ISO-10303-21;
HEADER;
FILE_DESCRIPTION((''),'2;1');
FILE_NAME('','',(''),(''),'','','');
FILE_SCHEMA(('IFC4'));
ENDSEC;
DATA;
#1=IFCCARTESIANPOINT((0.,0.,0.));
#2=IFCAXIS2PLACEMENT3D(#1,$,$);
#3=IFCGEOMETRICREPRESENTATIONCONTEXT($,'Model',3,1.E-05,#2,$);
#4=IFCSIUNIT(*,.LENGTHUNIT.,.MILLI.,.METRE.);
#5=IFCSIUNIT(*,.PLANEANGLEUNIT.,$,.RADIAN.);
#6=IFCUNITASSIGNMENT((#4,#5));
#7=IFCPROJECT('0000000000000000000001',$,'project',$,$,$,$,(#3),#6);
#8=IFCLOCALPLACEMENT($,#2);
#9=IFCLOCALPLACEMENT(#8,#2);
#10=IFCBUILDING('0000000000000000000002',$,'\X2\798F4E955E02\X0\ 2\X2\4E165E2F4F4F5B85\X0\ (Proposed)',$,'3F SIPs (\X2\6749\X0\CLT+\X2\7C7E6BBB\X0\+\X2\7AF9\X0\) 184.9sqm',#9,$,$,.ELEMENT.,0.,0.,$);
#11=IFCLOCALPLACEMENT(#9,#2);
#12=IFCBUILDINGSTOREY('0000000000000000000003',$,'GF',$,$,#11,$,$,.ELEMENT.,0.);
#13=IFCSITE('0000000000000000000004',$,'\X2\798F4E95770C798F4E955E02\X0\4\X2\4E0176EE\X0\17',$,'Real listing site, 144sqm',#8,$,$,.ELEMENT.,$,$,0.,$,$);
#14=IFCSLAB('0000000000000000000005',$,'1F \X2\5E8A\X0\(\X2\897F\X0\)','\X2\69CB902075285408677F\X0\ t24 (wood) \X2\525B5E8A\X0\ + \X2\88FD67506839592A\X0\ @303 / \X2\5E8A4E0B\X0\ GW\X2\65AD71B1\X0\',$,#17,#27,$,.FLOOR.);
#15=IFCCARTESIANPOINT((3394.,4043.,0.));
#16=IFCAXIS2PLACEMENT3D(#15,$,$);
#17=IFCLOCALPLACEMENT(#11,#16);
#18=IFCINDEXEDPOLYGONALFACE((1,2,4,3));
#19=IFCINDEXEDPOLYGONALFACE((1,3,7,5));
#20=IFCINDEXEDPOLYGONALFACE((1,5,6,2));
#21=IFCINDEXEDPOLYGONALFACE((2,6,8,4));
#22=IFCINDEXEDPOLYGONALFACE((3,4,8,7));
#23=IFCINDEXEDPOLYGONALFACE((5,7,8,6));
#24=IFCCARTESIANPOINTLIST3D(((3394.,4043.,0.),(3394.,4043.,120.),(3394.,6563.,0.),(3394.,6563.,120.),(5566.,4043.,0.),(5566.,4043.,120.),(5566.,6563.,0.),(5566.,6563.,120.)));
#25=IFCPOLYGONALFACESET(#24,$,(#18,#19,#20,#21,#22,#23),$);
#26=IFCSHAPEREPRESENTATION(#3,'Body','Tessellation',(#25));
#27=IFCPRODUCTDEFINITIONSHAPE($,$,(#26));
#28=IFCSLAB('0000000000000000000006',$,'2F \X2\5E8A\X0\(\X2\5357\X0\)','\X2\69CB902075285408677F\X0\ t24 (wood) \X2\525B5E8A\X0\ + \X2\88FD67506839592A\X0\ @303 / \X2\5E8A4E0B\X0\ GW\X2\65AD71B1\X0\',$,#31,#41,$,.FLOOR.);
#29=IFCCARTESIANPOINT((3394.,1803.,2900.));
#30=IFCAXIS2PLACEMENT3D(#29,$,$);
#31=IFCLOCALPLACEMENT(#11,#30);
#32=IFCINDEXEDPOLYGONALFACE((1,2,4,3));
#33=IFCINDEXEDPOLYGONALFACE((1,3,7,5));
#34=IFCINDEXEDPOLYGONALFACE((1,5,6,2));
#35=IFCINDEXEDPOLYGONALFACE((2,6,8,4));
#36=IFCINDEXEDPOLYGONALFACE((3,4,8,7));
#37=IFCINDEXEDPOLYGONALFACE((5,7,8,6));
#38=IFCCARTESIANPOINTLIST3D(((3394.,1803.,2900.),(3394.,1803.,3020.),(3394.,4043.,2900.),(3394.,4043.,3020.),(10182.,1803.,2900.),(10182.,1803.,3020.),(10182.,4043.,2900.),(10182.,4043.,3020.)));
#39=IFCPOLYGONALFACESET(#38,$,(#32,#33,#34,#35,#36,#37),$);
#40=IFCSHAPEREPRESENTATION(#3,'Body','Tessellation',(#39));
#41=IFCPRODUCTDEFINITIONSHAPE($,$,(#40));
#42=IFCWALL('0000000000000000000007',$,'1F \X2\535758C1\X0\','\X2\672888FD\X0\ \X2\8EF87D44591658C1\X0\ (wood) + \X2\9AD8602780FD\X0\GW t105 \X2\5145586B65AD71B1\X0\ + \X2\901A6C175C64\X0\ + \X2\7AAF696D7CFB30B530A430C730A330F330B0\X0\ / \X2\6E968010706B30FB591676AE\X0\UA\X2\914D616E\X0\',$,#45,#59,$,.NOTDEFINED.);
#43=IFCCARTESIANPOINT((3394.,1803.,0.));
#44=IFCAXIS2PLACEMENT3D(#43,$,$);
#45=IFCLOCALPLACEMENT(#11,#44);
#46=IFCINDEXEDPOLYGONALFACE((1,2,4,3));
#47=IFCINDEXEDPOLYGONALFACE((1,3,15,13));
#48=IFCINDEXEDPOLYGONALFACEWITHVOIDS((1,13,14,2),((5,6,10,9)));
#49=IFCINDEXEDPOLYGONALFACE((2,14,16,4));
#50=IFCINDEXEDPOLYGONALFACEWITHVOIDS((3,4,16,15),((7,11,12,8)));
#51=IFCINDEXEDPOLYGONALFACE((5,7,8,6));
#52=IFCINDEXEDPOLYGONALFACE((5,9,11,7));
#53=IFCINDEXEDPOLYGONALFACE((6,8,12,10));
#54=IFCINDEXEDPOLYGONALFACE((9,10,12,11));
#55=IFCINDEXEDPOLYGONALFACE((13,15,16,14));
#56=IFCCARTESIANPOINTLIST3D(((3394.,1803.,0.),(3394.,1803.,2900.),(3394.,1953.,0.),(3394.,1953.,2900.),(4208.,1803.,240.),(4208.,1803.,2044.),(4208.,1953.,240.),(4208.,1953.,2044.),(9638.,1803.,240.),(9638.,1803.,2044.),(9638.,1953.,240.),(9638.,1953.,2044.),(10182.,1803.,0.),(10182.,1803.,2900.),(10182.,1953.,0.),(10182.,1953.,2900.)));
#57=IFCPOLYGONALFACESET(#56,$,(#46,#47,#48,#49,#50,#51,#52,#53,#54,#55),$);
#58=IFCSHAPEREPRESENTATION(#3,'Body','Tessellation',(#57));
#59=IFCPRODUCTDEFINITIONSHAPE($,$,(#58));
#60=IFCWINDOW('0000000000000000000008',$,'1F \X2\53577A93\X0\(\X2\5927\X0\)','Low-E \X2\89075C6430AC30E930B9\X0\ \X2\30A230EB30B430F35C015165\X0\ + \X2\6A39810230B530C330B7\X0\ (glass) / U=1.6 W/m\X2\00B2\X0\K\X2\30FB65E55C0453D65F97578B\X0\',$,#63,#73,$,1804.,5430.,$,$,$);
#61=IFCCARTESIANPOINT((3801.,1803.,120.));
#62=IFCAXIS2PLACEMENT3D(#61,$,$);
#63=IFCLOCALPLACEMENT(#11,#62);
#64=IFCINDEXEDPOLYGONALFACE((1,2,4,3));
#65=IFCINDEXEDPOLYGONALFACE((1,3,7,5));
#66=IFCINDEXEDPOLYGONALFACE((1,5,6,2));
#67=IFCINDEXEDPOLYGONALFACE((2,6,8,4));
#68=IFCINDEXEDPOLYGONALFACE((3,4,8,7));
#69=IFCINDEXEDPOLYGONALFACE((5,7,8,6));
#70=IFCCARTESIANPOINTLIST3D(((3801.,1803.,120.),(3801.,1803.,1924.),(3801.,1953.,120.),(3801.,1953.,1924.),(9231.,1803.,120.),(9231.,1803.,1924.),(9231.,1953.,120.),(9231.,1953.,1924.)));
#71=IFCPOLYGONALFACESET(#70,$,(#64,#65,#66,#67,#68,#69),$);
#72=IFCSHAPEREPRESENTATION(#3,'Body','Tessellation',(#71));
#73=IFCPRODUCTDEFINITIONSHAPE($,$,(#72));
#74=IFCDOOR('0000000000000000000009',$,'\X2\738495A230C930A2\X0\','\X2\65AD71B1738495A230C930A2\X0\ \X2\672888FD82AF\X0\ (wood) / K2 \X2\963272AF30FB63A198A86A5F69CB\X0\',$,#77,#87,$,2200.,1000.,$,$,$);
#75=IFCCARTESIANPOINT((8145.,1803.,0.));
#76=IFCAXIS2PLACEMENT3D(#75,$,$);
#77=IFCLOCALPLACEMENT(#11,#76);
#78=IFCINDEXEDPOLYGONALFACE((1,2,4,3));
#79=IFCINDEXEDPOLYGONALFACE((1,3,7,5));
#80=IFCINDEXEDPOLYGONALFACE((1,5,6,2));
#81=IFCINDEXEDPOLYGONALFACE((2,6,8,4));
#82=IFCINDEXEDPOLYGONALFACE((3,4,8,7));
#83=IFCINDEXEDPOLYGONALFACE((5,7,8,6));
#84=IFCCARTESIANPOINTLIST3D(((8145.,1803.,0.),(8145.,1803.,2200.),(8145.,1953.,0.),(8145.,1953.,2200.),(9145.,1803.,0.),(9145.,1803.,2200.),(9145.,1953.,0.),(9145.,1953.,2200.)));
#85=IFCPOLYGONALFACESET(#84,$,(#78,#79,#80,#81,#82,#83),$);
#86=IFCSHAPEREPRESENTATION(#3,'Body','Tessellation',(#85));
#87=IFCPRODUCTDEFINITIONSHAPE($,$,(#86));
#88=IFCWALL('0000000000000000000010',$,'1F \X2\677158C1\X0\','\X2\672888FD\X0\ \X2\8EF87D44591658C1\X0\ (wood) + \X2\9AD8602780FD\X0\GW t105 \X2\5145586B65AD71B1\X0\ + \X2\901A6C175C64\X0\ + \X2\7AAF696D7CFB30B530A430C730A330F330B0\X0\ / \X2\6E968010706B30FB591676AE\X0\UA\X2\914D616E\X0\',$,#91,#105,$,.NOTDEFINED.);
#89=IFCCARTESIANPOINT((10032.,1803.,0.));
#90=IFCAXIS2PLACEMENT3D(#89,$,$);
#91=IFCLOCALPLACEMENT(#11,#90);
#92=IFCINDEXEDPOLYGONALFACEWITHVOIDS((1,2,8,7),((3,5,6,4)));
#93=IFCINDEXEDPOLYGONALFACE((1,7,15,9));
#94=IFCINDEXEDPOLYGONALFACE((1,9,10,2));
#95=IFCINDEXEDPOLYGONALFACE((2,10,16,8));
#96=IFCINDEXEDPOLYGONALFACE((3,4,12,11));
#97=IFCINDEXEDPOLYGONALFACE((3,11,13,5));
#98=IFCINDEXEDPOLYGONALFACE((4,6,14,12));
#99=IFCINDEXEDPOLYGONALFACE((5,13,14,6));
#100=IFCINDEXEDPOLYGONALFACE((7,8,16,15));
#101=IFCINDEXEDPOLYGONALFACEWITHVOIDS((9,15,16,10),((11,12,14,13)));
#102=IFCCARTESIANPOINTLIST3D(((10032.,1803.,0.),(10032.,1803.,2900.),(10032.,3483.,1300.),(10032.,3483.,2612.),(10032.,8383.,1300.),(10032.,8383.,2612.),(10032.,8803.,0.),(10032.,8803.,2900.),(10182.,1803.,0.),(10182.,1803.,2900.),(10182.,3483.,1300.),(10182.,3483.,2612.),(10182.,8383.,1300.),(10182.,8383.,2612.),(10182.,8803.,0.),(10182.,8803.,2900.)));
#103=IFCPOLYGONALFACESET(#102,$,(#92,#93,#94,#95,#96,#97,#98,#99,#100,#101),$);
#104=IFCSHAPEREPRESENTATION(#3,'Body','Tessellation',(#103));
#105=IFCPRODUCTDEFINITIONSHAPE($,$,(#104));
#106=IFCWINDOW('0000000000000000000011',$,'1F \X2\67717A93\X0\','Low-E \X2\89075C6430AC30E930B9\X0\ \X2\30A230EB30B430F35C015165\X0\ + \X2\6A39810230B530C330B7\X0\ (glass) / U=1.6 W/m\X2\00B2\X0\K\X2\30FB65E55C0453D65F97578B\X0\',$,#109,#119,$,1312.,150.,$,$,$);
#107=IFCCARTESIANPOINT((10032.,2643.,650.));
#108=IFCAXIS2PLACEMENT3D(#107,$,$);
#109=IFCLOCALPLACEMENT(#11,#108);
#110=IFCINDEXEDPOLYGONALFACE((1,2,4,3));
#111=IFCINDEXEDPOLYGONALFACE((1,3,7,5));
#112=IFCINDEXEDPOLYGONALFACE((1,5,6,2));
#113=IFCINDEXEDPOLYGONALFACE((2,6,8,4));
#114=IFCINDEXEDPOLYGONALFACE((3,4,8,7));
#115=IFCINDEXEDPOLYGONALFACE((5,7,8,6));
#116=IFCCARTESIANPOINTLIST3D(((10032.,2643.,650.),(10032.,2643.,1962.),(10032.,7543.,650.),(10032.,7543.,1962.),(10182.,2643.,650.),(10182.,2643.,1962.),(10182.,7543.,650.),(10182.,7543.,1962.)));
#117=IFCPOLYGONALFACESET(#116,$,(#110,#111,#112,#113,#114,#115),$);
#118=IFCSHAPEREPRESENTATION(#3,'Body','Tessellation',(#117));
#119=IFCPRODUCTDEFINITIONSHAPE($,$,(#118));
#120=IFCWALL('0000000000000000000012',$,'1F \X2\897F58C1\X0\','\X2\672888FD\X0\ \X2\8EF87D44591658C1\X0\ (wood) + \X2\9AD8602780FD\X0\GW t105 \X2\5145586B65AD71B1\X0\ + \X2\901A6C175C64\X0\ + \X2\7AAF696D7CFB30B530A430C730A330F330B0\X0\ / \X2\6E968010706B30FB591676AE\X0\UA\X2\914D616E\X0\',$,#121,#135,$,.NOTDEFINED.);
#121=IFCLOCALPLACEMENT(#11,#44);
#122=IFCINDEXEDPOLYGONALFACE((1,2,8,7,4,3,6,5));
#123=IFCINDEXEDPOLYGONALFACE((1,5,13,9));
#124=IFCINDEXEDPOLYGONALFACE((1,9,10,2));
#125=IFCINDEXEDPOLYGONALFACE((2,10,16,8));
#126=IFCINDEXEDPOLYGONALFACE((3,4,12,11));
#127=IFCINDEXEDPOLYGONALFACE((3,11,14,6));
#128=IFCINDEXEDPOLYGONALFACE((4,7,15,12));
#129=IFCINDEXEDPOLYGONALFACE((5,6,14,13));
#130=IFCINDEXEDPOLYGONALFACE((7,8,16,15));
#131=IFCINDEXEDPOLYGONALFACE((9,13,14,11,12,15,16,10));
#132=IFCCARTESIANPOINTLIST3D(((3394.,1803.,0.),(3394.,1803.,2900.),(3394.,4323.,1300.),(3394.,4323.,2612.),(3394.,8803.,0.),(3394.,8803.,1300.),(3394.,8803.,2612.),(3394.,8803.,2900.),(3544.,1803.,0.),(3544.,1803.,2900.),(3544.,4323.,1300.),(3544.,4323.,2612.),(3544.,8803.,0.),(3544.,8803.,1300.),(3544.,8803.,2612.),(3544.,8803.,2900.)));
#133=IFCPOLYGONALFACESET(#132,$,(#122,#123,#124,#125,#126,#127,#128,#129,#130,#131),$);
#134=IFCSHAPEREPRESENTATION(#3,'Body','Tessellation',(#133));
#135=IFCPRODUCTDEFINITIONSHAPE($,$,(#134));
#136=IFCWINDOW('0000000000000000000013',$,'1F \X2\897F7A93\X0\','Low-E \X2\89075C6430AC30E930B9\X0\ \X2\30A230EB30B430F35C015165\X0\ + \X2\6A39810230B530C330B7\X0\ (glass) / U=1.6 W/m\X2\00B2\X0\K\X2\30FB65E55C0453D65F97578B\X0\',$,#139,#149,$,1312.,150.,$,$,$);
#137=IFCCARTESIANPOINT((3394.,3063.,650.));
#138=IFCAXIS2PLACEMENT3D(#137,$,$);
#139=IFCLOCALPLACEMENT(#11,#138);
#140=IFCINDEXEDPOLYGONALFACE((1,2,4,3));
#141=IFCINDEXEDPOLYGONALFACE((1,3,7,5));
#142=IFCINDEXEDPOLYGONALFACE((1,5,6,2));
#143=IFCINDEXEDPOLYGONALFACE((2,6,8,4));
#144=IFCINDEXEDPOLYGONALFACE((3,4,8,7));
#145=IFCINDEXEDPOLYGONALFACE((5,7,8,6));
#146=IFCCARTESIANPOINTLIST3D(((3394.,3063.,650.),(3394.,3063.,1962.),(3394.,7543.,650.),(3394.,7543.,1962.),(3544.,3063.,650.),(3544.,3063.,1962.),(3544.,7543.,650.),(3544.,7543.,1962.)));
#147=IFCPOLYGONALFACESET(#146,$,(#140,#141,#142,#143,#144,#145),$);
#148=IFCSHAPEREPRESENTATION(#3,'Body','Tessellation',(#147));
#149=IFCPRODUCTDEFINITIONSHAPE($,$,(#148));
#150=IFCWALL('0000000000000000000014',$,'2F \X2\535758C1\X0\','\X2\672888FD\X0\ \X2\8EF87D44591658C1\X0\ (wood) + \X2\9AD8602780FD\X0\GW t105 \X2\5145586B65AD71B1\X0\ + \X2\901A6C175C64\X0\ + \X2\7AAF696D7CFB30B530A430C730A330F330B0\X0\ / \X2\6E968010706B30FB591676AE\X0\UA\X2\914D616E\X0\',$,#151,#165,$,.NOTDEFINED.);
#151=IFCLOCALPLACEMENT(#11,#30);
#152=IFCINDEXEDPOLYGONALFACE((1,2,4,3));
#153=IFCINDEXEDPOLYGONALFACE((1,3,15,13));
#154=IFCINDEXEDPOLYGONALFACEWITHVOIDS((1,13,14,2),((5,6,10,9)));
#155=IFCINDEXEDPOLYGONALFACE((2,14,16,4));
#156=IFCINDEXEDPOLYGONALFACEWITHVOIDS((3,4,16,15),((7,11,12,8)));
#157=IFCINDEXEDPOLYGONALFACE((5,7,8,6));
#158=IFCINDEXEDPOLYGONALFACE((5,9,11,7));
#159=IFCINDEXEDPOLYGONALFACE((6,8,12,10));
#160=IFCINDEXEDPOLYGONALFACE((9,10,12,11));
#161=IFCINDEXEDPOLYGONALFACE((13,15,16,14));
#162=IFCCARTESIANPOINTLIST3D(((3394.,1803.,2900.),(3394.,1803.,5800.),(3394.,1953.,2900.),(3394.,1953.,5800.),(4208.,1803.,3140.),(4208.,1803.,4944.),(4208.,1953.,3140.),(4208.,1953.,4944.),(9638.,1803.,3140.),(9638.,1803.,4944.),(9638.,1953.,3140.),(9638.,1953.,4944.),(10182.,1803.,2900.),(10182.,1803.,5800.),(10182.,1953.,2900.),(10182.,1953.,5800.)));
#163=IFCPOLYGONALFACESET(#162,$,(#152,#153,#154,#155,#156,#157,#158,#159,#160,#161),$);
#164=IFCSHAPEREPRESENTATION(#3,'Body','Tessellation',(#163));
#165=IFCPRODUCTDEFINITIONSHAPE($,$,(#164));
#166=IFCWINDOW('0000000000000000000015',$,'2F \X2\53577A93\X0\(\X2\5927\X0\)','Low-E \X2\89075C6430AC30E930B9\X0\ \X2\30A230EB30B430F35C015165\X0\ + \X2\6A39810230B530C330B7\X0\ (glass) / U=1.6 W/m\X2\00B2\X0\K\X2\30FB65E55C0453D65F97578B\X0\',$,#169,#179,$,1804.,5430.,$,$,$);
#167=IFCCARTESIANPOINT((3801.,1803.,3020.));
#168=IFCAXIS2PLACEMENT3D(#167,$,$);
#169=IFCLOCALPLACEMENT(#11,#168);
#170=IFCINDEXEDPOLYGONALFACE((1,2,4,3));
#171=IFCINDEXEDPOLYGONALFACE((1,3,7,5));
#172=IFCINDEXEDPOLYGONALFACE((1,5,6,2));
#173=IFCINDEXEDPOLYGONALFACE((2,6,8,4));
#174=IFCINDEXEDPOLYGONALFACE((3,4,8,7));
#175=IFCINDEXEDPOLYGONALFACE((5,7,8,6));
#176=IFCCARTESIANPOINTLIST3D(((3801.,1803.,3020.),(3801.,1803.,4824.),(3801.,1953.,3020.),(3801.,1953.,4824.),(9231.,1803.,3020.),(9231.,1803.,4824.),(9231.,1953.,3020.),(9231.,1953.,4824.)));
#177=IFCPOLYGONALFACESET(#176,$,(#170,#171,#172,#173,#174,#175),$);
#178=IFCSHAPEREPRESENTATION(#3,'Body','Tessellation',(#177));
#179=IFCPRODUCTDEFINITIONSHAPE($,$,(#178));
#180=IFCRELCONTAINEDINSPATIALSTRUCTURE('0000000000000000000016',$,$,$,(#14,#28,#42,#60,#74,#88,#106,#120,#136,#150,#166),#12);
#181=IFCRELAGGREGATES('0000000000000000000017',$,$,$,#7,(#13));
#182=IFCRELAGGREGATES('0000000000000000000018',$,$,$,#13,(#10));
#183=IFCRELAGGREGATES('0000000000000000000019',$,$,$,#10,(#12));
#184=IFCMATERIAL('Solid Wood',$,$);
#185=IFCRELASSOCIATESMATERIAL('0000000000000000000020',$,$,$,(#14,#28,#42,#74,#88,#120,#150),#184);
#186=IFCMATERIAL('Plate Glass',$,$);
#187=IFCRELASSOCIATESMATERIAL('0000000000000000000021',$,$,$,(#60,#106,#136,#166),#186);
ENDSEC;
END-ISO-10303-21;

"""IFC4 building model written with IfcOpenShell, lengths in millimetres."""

from ifc_helpers import new_model, si_unit, frame, frame_2d, origin, place, context, project, spatial, rectangle, extrude, material, element, fill, save


model = new_model("IFC4")

# Units and contexts
model_context = context("Model", 3, precision=1e-05, world=origin())
ifc_project = project(units=[si_unit("LENGTHUNIT", "METRE", prefix="MILLI"), si_unit("PLANEANGLEUNIT", "RADIAN")], contexts=[model_context])

# Site, building, storey
site_placement = place(None, origin())
site = spatial("IfcSite", under=ifc_project, at=site_placement, Name="福井県福井市4丁目17", ObjectType="Real listing site, 144sqm", CompositionType="ELEMENT", RefElevation=0.0)
building_placement = place(site_placement, origin())
building = spatial("IfcBuilding", under=site, at=building_placement, Name="福井市 2世帯住宅 (Proposed)", ObjectType="3F SIPs (杉CLT+籾殻+竹) 184.9sqm", CompositionType="ELEMENT", ElevationOfRefHeight=0.0, ElevationOfTerrain=0.0)
storey_placement = place(building_placement, origin())
storey = spatial("IfcBuildingStorey", under=building, at=storey_placement, Name="GF", CompositionType="ELEMENT", Elevation=0.0)

# Slabs
ifc_material_1 = material(Name="Solid Wood")
slab_1_placement = place(storey_placement, frame((3394.0, 4043.0, 0.0)))
element("IfcSlab", 1, at=slab_1_placement, inside=storey, material=ifc_material_1, Name="1F 床(西)", Description="構造用合板 t24 (wood) 剛床 + 製材根太 @303 / 床下 GW断熱", PredefinedType="FLOOR", context=model_context, shape_type="SweptSolid", body=[
    extrude(rectangle(XDim=2172.0, YDim=2520.0, at=frame_2d((1086.0, 1260.0))), frame((3394.0, 4043.0, 0.0)), (0.0, 0.0, 1.0), 120.0),
])
slab_2_placement = place(storey_placement, frame((3394.0, 1803.0, 2900.0)))
element("IfcSlab", 2, at=slab_2_placement, inside=storey, material=ifc_material_1, Name="2F 床(南)", Description="構造用合板 t24 (wood) 剛床 + 製材根太 @303 / 床下 GW断熱", PredefinedType="FLOOR", context=model_context, shape_type="SweptSolid", body=[
    extrude(rectangle(XDim=6788.0, YDim=2240.0, at=frame_2d((3394.0, 1120.0))), frame((3394.0, 1803.0, 2900.0)), (0.0, 0.0, 1.0), 120.0),
])

# Wall, openings, window, door
wall_1_placement = place(storey_placement, frame((3394.0, 1803.0, 0.0)))
wall_1 = element("IfcWall", 3, at=wall_1_placement, inside=storey, material=ifc_material_1, Name="1F 南壁", Description="木製 軸組外壁 (wood) + 高性能GW t105 充填断熱 + 通気層 + 窯業系サイディング / 準耐火・外皮UA配慮", PredefinedType="NOTDEFINED", context=model_context, shape_type="SweptSolid", body=[
    extrude(rectangle(XDim=6788.0, YDim=150.0, at=frame_2d((3394.0, 75.0))), frame((3394.0, 1803.0, 0.0)), (0.0, 0.0, 1.0), 2900.0),
])
opening_1_placement = place(storey_placement, frame((3801.0, 1803.0, 120.0)))
opening_1 = element("IfcOpeningElement", 4, at=opening_1_placement, cuts=wall_1, PredefinedType="NOTDEFINED", context=model_context, shape_type="SweptSolid", body=[
    extrude(rectangle(XDim=5430.0, YDim=150.0, at=frame_2d((2715.0, 75.0))), frame((3801.0, 1803.0, 120.0)), (0.0, 0.0, 1.0), 1804.0),
])
opening_2_placement = place(storey_placement, frame((8145.0, 1803.0, 0.0)))
opening_2 = element("IfcOpeningElement", 5, at=opening_2_placement, cuts=wall_1, PredefinedType="NOTDEFINED", context=model_context, shape_type="SweptSolid", body=[
    extrude(rectangle(XDim=1000.0, YDim=150.0, at=frame_2d((500.0, 75.0))), frame((8145.0, 1803.0, 0.0)), (0.0, 0.0, 1.0), 2200.0),
])
ifc_material_2 = material(Name="Plate Glass")
window_1_placement = place(storey_placement, frame((3801.0, 1803.0, 120.0)))
window_1 = element("IfcWindow", 6, at=window_1_placement, inside=storey, material=ifc_material_2, Name="1F 南窓(大)", Description="Low-E 複層ガラス アルゴン封入 + 樹脂サッシ (glass) / U=1.6 W/m²K・日射取得型", OverallHeight=1804.0, OverallWidth=5430.0, context=model_context, shape_type="SweptSolid", body=[
    extrude(rectangle(XDim=5430.0, YDim=150.0, at=frame_2d((2715.0, 75.0))), frame((3801.0, 1803.0, 120.0)), (0.0, 0.0, 1.0), 1804.0),
])
fill(opening_1, window_1)
door_placement = place(storey_placement, frame((8145.0, 1803.0, 0.0)))
door = element("IfcDoor", 7, at=door_placement, inside=storey, material=ifc_material_1, Name="玄関ドア", Description="断熱玄関ドア 木製芯 (wood) / K2 防犯・採風機構", OverallHeight=2200.0, OverallWidth=1000.0, context=model_context, shape_type="SweptSolid", body=[
    extrude(rectangle(XDim=1000.0, YDim=150.0, at=frame_2d((500.0, 75.0))), frame((8145.0, 1803.0, 0.0)), (0.0, 0.0, 1.0), 2200.0),
])
fill(opening_2, door)

# Walls, openings, windows
wall_2_placement = place(storey_placement, frame((10032.0, 1803.0, 0.0)))
wall_2 = element("IfcWall", 8, at=wall_2_placement, inside=storey, material=ifc_material_1, Name="1F 東壁", Description="木製 軸組外壁 (wood) + 高性能GW t105 充填断熱 + 通気層 + 窯業系サイディング / 準耐火・外皮UA配慮", PredefinedType="NOTDEFINED", context=model_context, shape_type="SweptSolid", body=[
    extrude(rectangle(XDim=150.0, YDim=7000.0, at=frame_2d((75.0, 3500.0))), frame((10032.0, 1803.0, 0.0)), (0.0, 0.0, 1.0), 2900.0),
])
opening_3_placement = place(storey_placement, frame((10032.0, 2643.0, 650.0)))
opening_3 = element("IfcOpeningElement", 9, at=opening_3_placement, cuts=wall_2, PredefinedType="NOTDEFINED", context=model_context, shape_type="SweptSolid", body=[
    extrude(rectangle(XDim=150.0, YDim=4900.0, at=frame_2d((75.0, 2450.0))), frame((10032.0, 2643.0, 650.0)), (0.0, 0.0, 1.0), 1312.0),
])
window_2_placement = place(storey_placement, frame((10032.0, 2643.0, 650.0)))
window_2 = element("IfcWindow", 10, at=window_2_placement, inside=storey, material=ifc_material_2, Name="1F 東窓", Description="Low-E 複層ガラス アルゴン封入 + 樹脂サッシ (glass) / U=1.6 W/m²K・日射取得型", OverallHeight=1312.0, OverallWidth=150.0, context=model_context, shape_type="SweptSolid", body=[
    extrude(rectangle(XDim=150.0, YDim=4900.0, at=frame_2d((75.0, 2450.0))), frame((10032.0, 2643.0, 650.0)), (0.0, 0.0, 1.0), 1312.0),
])
fill(opening_3, window_2)
wall_3_placement = place(storey_placement, frame((3394.0, 1803.0, 0.0)))
wall_3 = element("IfcWall", 11, at=wall_3_placement, inside=storey, material=ifc_material_1, Name="1F 西壁", Description="木製 軸組外壁 (wood) + 高性能GW t105 充填断熱 + 通気層 + 窯業系サイディング / 準耐火・外皮UA配慮", PredefinedType="NOTDEFINED", context=model_context, shape_type="SweptSolid", body=[
    extrude(rectangle(XDim=150.0, YDim=7000.0, at=frame_2d((75.0, 3500.0))), frame((3394.0, 1803.0, 0.0)), (0.0, 0.0, 1.0), 2900.0),
])
opening_4_placement = place(storey_placement, frame((3394.0, 3063.0, 650.0)))
opening_4 = element("IfcOpeningElement", 12, at=opening_4_placement, cuts=wall_3, PredefinedType="NOTDEFINED", context=model_context, shape_type="SweptSolid", body=[
    extrude(rectangle(XDim=150.0, YDim=4480.0, at=frame_2d((75.0, 2240.0))), frame((3394.0, 3063.0, 650.0)), (0.0, 0.0, 1.0), 1312.0),
])
window_3_placement = place(storey_placement, frame((3394.0, 3063.0, 650.0)))
window_3 = element("IfcWindow", 13, at=window_3_placement, inside=storey, material=ifc_material_2, Name="1F 西窓", Description="Low-E 複層ガラス アルゴン封入 + 樹脂サッシ (glass) / U=1.6 W/m²K・日射取得型", OverallHeight=1312.0, OverallWidth=150.0, context=model_context, shape_type="SweptSolid", body=[
    extrude(rectangle(XDim=150.0, YDim=4480.0, at=frame_2d((75.0, 2240.0))), frame((3394.0, 3063.0, 650.0)), (0.0, 0.0, 1.0), 1312.0),
])
fill(opening_4, window_3)
wall_4_placement = place(storey_placement, frame((3394.0, 1803.0, 2900.0)))
wall_4 = element("IfcWall", 14, at=wall_4_placement, inside=storey, material=ifc_material_1, Name="2F 南壁", Description="木製 軸組外壁 (wood) + 高性能GW t105 充填断熱 + 通気層 + 窯業系サイディング / 準耐火・外皮UA配慮", PredefinedType="NOTDEFINED", context=model_context, shape_type="SweptSolid", body=[
    extrude(rectangle(XDim=6788.0, YDim=150.0, at=frame_2d((3394.0, 75.0))), frame((3394.0, 1803.0, 2900.0)), (0.0, 0.0, 1.0), 2900.0),
])
opening_5_placement = place(storey_placement, frame((3801.0, 1803.0, 3020.0)))
opening_5 = element("IfcOpeningElement", 15, at=opening_5_placement, cuts=wall_4, PredefinedType="NOTDEFINED", context=model_context, shape_type="SweptSolid", body=[
    extrude(rectangle(XDim=5430.0, YDim=150.0, at=frame_2d((2715.0, 75.0))), frame((3801.0, 1803.0, 3020.0)), (0.0, 0.0, 1.0), 1804.0),
])
window_4_placement = place(storey_placement, frame((3801.0, 1803.0, 3020.0)))
window_4 = element("IfcWindow", 16, at=window_4_placement, inside=storey, material=ifc_material_2, Name="2F 南窓(大)", Description="Low-E 複層ガラス アルゴン封入 + 樹脂サッシ (glass) / U=1.6 W/m²K・日射取得型", OverallHeight=1804.0, OverallWidth=5430.0, context=model_context, shape_type="SweptSolid", body=[
    extrude(rectangle(XDim=5430.0, YDim=150.0, at=frame_2d((2715.0, 75.0))), frame((3801.0, 1803.0, 3020.0)), (0.0, 0.0, 1.0), 1804.0),
])
fill(opening_5, window_4)

save(model, "model.ifc")
